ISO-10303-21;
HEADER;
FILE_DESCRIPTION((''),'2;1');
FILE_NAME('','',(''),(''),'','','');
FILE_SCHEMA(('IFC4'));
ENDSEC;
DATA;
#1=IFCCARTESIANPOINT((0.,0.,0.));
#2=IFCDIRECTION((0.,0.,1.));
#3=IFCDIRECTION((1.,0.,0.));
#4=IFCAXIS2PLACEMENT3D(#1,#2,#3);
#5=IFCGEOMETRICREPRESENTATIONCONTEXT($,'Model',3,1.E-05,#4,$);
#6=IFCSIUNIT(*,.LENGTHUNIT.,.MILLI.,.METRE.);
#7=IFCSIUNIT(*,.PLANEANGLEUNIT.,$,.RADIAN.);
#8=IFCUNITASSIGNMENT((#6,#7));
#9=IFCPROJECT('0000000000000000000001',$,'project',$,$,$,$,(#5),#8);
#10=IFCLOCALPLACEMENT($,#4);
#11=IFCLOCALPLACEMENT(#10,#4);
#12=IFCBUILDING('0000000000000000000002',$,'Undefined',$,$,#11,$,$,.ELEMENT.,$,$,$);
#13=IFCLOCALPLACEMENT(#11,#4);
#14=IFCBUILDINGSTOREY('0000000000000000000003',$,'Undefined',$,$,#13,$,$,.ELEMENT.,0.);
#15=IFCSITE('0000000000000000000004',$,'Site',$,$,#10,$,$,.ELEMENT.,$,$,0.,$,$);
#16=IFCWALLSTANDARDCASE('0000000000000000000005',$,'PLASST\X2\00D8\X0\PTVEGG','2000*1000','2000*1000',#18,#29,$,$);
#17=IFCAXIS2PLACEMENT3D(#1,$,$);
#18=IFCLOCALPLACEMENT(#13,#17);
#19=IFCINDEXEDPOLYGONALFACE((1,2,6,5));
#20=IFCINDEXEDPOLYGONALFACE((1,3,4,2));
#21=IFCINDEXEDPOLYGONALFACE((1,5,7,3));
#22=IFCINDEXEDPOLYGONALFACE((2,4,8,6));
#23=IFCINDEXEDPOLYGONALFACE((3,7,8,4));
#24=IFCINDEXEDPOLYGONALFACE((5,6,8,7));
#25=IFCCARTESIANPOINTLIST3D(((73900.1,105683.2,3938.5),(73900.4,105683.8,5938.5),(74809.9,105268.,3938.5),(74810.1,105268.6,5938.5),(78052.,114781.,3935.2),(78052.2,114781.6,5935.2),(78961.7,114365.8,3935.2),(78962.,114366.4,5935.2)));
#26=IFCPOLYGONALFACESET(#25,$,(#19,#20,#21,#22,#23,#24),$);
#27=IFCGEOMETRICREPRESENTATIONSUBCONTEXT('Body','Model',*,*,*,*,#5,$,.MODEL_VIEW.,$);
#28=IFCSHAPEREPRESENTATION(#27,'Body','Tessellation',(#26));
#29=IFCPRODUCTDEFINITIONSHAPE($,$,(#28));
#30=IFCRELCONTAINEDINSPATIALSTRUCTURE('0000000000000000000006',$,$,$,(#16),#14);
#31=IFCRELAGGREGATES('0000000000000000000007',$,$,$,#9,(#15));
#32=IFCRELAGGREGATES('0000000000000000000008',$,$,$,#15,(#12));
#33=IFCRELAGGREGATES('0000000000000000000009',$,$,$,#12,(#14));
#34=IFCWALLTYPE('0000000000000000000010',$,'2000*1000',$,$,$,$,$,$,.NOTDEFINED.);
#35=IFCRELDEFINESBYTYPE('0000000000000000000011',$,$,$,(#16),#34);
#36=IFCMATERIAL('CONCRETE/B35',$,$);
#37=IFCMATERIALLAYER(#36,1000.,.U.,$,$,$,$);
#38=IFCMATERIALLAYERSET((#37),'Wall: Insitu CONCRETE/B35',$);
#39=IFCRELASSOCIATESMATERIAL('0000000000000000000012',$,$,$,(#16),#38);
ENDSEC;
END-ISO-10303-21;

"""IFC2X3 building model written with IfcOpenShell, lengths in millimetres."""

from ifc_helpers import new_model, si_unit, frame, frame_2d, origin_with_axes, place, context, subcontext, project, spatial, rectangle, extrude, material, layer, layer_set, layer_usage, type_object, element, save


model = new_model("IFC2X3")

# Units and contexts
model_context = context("Model", 3, precision=1e-05, world=origin_with_axes())
body_context = subcontext(model_context, "Body", "Model", "MODEL_VIEW")
ifc_project = project(units=[si_unit("LENGTHUNIT", "METRE", prefix="MILLI"), si_unit("PLANEANGLEUNIT", "RADIAN")], contexts=[model_context])

# Site, building, storey
site_placement = place(None, origin_with_axes())
site = spatial("IfcSite", under=ifc_project, at=site_placement, Name="Site", CompositionType="ELEMENT", RefElevation=0.0)
building_placement = place(site_placement, origin_with_axes())
building = spatial("IfcBuilding", under=site, at=building_placement, Name="Undefined", CompositionType="ELEMENT")
storey_placement = place(building_placement, origin_with_axes())
storey = spatial("IfcBuildingStorey", under=building, at=storey_placement, Name="Undefined", CompositionType="ELEMENT", Elevation=0.0)

# Shared definitions
ifc_material_1 = material(Name="CONCRETE/B35")

# Wall
ifc_layer_1 = layer(ifc_material_1, 1000.0, ventilated="UNKNOWN")
ifc_layer_set_1 = layer_set([ifc_layer_1], Name="Wall: Insitu CONCRETE/B35")
ifc_layer_usage_1 = layer_usage(ifc_layer_set_1, "AXIS2", "POSITIVE", -500.0)
wall_type = type_object("IfcWallType", Name="2000*1000", PredefinedType="NOTDEFINED")
wall_placement = place(storey_placement, frame((78506.8, 114573.4, 3935.2), z_axis=(0.000135, 0.000296, 1.0), x_axis=(-0.41517, -0.909744, 0.000326)))
element("IfcWallStandardCase", 1, at=wall_placement, inside=storey, type_object=wall_type, material=ifc_layer_usage_1, Name="PLASSTØPTVEGG", Description="2000*1000", ObjectType="2000*1000", context=body_context, shape_type="SweptSolid", body=[
    extrude(rectangle(XDim=10000.4, YDim=1000.0, at=frame_2d((0.0, 5000.2), x_axis=(0.0, -1.0))), frame((0.0, 0.0, 0.0), z_axis=(0.0, 0.0, 1.0), x_axis=(0.0, -1.0, 0.0)), (0.0, 0.0, 1.0), 2000.0),
])

save(model, "model.ifc")
